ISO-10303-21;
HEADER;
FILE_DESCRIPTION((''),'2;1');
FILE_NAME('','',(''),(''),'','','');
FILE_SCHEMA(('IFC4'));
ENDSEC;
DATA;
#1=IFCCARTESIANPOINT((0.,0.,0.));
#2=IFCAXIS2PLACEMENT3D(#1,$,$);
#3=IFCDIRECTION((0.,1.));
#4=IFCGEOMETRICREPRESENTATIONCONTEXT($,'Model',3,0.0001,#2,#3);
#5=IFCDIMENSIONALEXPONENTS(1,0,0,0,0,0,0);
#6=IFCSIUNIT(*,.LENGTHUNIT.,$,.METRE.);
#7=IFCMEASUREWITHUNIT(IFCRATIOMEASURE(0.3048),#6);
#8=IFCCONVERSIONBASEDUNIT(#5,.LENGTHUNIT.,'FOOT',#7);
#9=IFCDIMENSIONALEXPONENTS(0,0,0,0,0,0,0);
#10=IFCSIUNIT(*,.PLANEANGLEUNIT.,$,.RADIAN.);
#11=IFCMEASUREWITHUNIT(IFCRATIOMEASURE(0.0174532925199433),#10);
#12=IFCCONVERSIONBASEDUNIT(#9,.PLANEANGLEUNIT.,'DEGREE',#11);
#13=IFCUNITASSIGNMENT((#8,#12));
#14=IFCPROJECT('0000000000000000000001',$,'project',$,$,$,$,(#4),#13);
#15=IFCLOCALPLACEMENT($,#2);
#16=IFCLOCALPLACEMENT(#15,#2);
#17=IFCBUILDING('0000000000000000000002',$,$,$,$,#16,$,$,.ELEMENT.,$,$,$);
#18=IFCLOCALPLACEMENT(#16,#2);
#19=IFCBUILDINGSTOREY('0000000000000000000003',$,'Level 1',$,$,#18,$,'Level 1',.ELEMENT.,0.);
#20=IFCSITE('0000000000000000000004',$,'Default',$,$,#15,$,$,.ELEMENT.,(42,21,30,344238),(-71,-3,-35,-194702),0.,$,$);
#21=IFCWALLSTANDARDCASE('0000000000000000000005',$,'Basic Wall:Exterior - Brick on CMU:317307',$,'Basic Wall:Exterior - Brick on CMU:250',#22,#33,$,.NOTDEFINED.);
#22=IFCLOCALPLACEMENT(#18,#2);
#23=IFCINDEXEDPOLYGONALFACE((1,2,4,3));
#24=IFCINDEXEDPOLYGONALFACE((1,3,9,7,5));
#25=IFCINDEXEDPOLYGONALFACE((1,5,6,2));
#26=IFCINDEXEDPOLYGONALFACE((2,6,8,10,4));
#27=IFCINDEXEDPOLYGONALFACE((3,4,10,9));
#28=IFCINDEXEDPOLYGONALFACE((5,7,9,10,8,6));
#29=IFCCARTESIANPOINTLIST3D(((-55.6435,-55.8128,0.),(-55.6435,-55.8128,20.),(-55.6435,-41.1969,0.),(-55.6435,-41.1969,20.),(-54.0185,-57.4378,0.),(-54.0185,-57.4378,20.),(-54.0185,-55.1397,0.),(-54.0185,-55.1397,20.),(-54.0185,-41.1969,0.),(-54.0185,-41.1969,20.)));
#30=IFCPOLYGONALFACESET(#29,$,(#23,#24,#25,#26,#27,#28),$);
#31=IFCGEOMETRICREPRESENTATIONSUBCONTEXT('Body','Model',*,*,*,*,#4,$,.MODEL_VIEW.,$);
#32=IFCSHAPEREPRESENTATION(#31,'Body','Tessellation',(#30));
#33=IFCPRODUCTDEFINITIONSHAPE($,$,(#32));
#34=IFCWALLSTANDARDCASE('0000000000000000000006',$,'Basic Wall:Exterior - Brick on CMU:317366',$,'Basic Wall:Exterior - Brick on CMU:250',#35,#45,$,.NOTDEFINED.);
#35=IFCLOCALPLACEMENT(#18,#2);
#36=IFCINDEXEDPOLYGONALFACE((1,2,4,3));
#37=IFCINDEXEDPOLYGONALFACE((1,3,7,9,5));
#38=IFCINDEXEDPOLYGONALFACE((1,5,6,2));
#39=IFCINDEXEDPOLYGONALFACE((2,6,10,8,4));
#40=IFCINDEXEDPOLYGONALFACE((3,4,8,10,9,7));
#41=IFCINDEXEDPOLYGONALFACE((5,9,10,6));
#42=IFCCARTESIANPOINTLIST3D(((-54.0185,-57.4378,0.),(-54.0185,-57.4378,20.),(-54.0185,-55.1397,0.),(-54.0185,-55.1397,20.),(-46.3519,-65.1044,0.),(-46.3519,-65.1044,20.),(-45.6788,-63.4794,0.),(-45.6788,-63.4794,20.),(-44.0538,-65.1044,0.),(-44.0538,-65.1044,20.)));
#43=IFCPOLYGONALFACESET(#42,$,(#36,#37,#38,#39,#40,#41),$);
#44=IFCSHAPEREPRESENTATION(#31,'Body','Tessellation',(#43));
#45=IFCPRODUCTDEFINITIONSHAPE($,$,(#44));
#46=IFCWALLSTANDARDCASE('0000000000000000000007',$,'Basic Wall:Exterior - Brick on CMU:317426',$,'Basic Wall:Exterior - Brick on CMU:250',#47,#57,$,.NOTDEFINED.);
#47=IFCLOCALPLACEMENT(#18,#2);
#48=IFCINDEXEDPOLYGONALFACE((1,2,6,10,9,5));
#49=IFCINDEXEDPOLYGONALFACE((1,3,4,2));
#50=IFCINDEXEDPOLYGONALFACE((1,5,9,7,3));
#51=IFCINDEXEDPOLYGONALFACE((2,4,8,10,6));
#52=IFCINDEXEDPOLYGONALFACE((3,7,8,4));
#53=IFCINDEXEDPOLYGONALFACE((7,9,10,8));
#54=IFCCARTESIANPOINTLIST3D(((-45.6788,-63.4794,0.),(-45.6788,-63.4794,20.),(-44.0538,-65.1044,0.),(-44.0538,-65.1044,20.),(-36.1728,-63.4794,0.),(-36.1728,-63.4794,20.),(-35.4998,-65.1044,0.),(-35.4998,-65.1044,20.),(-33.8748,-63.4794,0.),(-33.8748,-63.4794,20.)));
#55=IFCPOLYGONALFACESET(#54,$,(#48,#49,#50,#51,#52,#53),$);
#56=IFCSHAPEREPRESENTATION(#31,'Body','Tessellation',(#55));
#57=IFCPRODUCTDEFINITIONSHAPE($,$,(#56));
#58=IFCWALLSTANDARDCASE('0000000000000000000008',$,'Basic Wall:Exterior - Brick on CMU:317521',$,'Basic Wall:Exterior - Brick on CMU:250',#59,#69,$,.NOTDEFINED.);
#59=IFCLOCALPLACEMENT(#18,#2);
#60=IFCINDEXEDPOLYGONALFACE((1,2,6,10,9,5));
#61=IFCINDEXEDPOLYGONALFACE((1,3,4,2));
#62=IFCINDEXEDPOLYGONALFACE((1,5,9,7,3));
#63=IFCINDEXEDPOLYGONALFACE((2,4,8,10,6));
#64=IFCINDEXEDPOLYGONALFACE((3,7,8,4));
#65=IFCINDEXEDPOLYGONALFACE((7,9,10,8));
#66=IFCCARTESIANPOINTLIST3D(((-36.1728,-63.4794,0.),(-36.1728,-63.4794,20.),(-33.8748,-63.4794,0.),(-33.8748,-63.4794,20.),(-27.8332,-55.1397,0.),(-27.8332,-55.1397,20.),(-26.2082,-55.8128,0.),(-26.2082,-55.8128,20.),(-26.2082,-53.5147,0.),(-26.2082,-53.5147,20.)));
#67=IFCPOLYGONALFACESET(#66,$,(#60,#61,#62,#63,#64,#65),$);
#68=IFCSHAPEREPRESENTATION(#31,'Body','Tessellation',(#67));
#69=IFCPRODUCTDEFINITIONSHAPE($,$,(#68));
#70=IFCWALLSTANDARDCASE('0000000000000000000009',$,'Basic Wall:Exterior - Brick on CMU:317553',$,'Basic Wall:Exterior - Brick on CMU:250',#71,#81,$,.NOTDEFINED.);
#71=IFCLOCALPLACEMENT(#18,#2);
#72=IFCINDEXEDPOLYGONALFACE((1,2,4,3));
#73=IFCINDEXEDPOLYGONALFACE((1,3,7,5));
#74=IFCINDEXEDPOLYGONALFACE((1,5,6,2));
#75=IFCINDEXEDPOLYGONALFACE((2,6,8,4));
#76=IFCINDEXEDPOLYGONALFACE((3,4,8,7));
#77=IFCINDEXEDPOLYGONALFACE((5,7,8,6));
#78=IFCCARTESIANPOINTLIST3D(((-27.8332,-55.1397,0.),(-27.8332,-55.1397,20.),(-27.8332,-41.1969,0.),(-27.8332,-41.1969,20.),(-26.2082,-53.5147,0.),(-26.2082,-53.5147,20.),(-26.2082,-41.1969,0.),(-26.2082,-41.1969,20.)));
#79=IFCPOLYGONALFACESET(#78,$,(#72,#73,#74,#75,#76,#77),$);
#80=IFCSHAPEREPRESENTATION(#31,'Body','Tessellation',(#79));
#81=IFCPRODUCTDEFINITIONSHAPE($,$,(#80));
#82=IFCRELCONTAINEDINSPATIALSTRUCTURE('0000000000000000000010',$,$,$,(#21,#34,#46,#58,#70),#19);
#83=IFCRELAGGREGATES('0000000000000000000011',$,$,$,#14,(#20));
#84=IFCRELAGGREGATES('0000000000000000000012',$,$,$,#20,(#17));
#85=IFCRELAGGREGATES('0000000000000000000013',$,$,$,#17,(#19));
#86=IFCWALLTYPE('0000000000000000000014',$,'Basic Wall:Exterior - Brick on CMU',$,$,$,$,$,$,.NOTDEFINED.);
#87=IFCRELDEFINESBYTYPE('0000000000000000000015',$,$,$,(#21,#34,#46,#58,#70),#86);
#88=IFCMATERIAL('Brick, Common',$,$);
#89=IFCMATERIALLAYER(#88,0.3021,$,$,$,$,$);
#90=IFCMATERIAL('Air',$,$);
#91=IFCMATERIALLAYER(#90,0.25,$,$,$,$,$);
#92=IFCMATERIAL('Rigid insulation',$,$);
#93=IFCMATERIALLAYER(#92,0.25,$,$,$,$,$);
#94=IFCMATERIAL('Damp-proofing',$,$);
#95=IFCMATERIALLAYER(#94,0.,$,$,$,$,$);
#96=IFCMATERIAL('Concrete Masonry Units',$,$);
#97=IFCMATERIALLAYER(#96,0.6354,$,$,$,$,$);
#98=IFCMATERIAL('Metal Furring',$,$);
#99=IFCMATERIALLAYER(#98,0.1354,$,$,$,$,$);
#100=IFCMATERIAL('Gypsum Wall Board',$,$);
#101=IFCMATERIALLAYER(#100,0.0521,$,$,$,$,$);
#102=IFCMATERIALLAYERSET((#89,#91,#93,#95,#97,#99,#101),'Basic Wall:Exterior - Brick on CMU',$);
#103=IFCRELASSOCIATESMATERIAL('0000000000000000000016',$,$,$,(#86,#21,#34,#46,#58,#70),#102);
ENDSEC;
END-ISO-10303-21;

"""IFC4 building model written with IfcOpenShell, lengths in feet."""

from ifc_helpers import new_model, entity, si_unit, converted_unit, direction, frame, origin, place, context, subcontext, project, spatial, polyline, outline, extrude, material, layer, layer_set, layer_usage, type_object, element, save


model = new_model("IFC4")

# Units and contexts
model_context = context("Model", 3, precision=0.0001, world=origin(), true_north=direction((0.0, 1.0)))
body_context = subcontext(model_context, "Body", "Model", "MODEL_VIEW")
ifc_project = project(units=[converted_unit("LENGTHUNIT", "FOOT", entity("IfcRatioMeasure", 0.3048), si_unit("LENGTHUNIT", "METRE"), dimensions=[1, 0, 0, 0, 0, 0, 0]), converted_unit("PLANEANGLEUNIT", "DEGREE", entity("IfcRatioMeasure", 0.0174532925199433), si_unit("PLANEANGLEUNIT", "RADIAN"), dimensions=[0, 0, 0, 0, 0, 0, 0])], contexts=[model_context])

# Site, building, storey
site_placement = place(None, origin())
site = spatial("IfcSite", under=ifc_project, at=site_placement, Name="Default", CompositionType="ELEMENT", RefLatitude=(42, 21, 30, 344238), RefLongitude=(-71, -3, -35, -194702), RefElevation=0.0)
building_placement = place(site_placement, origin())
building = spatial("IfcBuilding", under=site, at=building_placement, CompositionType="ELEMENT")
storey_placement = place(building_placement, origin())
storey = spatial("IfcBuildingStorey", under=building, at=storey_placement, Name="Level 1", LongName="Level 1", CompositionType="ELEMENT", Elevation=0.0)

# Walls
ifc_material_1 = material(Name="Brick, Common")
ifc_layer_1 = layer(ifc_material_1, 0.3021)
ifc_material_2 = material(Name="Air")
ifc_layer_2 = layer(ifc_material_2, 0.25)
ifc_material_3 = material(Name="Rigid insulation")
ifc_layer_3 = layer(ifc_material_3, 0.25)
ifc_material_4 = material(Name="Damp-proofing")
ifc_layer_4 = layer(ifc_material_4, 0.0)
ifc_material_5 = material(Name="Concrete Masonry Units")
ifc_layer_5 = layer(ifc_material_5, 0.6354)
ifc_material_6 = material(Name="Metal Furring")
ifc_layer_6 = layer(ifc_material_6, 0.1354)
ifc_material_7 = material(Name="Gypsum Wall Board")
ifc_layer_7 = layer(ifc_material_7, 0.0521)
ifc_layer_set = layer_set([ifc_layer_1, ifc_layer_2, ifc_layer_3, ifc_layer_4, ifc_layer_5, ifc_layer_6, ifc_layer_7], Name="Basic Wall:Exterior - Brick on CMU")
wall_type = type_object("IfcWallType", Name="Basic Wall:Exterior - Brick on CMU", PredefinedType="NOTDEFINED", material=ifc_layer_set)
ifc_layer_usage_1 = layer_usage(ifc_layer_set, "AXIS2", "NEGATIVE", 0.8125)
wall_1_placement = place(storey_placement, frame((-54.831, -41.1969, 0.0), z_axis=(0.0, 0.0, 1.0), x_axis=(0.0, -1.0, 0.0)))
element("IfcWallStandardCase", 1, at=wall_1_placement, inside=storey, type_object=wall_type, material=ifc_layer_usage_1, Name="Basic Wall:Exterior - Brick on CMU:317307", ObjectType="Basic Wall:Exterior - Brick on CMU:250", PredefinedType="NOTDEFINED", context=body_context, shape_type="SweptSolid", body=[
    extrude(outline(polyline([(14.6159, -0.8125), (16.2409, 0.8125), (13.9428, 0.8125), (0.0, 0.8125), (0.0, -0.8125), (14.6159, -0.8125)])), origin(), (0.0, 0.0, 1.0), 20.0),
])
ifc_layer_usage_2 = layer_usage(ifc_layer_set, "AXIS2", "NEGATIVE", 0.8125)
wall_2_placement = place(storey_placement, frame((-44.6283, -65.6789, 0.0), z_axis=(0.0, 0.0, 1.0), x_axis=(-0.707107, 0.707107, 0.0)))
element("IfcWallStandardCase", 2, at=wall_2_placement, inside=storey, type_object=wall_type, material=ifc_layer_usage_2, Name="Basic Wall:Exterior - Brick on CMU:317366", ObjectType="Basic Wall:Exterior - Brick on CMU:250", PredefinedType="NOTDEFINED", context=body_context, shape_type="SweptSolid", body=[
    extrude(outline(polyline([(14.0922, -0.8125), (12.4672, 0.8125), (1.625, 0.8125), (0.0, -0.8125), (2.2981, -0.8125), (14.0922, -0.8125)])), origin(), (0.0, 0.0, 1.0), 20.0),
])
ifc_layer_usage_3 = layer_usage(ifc_layer_set, "AXIS2", "NEGATIVE", 0.8125)
wall_3_placement = place(storey_placement, frame((-33.8748, -64.2919, 0.0), z_axis=(0.0, 0.0, 1.0), x_axis=(-1.0, 0.0, 0.0)))
element("IfcWallStandardCase", 3, at=wall_3_placement, inside=storey, type_object=wall_type, material=ifc_layer_usage_3, Name="Basic Wall:Exterior - Brick on CMU:317426", ObjectType="Basic Wall:Exterior - Brick on CMU:250", PredefinedType="NOTDEFINED", context=body_context, shape_type="SweptSolid", body=[
    extrude(outline(polyline([(11.8041, -0.8125), (10.1791, 0.8125), (1.625, 0.8125), (0.0, -0.8125), (2.2981, -0.8125), (11.8041, -0.8125)])), origin(), (0.0, 0.0, 1.0), 20.0),
])
ifc_layer_usage_4 = layer_usage(ifc_layer_set, "AXIS2", "POSITIVE", -0.8125)
wall_4_placement = place(storey_placement, frame((-35.5983, -64.0539, 0.0), z_axis=(0.0, 0.0, 1.0), x_axis=(0.707107, 0.707107, 0.0)))
element("IfcWallStandardCase", 4, at=wall_4_placement, inside=storey, type_object=wall_type, material=ifc_layer_usage_4, Name="Basic Wall:Exterior - Brick on CMU:317521", ObjectType="Basic Wall:Exterior - Brick on CMU:250", PredefinedType="NOTDEFINED", context=body_context, shape_type="SweptSolid", body=[
    extrude(outline(polyline([(12.4672, -0.8125), (14.0922, 0.8125), (11.7941, 0.8125), (0.0, 0.8125), (1.625, -0.8125), (12.4672, -0.8125)])), origin(), (0.0, 0.0, 1.0), 20.0),
])
ifc_layer_usage_5 = layer_usage(ifc_layer_set, "AXIS2", "POSITIVE", -0.8125)
wall_5_placement = place(storey_placement, frame((-27.0207, -41.1969, 0.0), z_axis=(0.0, 0.0, 1.0), x_axis=(0.0, -1.0, 0.0)))
element("IfcWallStandardCase", 5, at=wall_5_placement, inside=storey, type_object=wall_type, material=ifc_layer_usage_5, Name="Basic Wall:Exterior - Brick on CMU:317553", ObjectType="Basic Wall:Exterior - Brick on CMU:250", PredefinedType="NOTDEFINED", context=body_context, shape_type="SweptSolid", body=[
    extrude(outline(polyline([(13.9428, -0.8125), (12.3178, 0.8125), (0.0, 0.8125), (0.0, -0.8125), (13.9428, -0.8125)])), origin(), (0.0, 0.0, 1.0), 20.0),
])

save(model, "model.ifc")
